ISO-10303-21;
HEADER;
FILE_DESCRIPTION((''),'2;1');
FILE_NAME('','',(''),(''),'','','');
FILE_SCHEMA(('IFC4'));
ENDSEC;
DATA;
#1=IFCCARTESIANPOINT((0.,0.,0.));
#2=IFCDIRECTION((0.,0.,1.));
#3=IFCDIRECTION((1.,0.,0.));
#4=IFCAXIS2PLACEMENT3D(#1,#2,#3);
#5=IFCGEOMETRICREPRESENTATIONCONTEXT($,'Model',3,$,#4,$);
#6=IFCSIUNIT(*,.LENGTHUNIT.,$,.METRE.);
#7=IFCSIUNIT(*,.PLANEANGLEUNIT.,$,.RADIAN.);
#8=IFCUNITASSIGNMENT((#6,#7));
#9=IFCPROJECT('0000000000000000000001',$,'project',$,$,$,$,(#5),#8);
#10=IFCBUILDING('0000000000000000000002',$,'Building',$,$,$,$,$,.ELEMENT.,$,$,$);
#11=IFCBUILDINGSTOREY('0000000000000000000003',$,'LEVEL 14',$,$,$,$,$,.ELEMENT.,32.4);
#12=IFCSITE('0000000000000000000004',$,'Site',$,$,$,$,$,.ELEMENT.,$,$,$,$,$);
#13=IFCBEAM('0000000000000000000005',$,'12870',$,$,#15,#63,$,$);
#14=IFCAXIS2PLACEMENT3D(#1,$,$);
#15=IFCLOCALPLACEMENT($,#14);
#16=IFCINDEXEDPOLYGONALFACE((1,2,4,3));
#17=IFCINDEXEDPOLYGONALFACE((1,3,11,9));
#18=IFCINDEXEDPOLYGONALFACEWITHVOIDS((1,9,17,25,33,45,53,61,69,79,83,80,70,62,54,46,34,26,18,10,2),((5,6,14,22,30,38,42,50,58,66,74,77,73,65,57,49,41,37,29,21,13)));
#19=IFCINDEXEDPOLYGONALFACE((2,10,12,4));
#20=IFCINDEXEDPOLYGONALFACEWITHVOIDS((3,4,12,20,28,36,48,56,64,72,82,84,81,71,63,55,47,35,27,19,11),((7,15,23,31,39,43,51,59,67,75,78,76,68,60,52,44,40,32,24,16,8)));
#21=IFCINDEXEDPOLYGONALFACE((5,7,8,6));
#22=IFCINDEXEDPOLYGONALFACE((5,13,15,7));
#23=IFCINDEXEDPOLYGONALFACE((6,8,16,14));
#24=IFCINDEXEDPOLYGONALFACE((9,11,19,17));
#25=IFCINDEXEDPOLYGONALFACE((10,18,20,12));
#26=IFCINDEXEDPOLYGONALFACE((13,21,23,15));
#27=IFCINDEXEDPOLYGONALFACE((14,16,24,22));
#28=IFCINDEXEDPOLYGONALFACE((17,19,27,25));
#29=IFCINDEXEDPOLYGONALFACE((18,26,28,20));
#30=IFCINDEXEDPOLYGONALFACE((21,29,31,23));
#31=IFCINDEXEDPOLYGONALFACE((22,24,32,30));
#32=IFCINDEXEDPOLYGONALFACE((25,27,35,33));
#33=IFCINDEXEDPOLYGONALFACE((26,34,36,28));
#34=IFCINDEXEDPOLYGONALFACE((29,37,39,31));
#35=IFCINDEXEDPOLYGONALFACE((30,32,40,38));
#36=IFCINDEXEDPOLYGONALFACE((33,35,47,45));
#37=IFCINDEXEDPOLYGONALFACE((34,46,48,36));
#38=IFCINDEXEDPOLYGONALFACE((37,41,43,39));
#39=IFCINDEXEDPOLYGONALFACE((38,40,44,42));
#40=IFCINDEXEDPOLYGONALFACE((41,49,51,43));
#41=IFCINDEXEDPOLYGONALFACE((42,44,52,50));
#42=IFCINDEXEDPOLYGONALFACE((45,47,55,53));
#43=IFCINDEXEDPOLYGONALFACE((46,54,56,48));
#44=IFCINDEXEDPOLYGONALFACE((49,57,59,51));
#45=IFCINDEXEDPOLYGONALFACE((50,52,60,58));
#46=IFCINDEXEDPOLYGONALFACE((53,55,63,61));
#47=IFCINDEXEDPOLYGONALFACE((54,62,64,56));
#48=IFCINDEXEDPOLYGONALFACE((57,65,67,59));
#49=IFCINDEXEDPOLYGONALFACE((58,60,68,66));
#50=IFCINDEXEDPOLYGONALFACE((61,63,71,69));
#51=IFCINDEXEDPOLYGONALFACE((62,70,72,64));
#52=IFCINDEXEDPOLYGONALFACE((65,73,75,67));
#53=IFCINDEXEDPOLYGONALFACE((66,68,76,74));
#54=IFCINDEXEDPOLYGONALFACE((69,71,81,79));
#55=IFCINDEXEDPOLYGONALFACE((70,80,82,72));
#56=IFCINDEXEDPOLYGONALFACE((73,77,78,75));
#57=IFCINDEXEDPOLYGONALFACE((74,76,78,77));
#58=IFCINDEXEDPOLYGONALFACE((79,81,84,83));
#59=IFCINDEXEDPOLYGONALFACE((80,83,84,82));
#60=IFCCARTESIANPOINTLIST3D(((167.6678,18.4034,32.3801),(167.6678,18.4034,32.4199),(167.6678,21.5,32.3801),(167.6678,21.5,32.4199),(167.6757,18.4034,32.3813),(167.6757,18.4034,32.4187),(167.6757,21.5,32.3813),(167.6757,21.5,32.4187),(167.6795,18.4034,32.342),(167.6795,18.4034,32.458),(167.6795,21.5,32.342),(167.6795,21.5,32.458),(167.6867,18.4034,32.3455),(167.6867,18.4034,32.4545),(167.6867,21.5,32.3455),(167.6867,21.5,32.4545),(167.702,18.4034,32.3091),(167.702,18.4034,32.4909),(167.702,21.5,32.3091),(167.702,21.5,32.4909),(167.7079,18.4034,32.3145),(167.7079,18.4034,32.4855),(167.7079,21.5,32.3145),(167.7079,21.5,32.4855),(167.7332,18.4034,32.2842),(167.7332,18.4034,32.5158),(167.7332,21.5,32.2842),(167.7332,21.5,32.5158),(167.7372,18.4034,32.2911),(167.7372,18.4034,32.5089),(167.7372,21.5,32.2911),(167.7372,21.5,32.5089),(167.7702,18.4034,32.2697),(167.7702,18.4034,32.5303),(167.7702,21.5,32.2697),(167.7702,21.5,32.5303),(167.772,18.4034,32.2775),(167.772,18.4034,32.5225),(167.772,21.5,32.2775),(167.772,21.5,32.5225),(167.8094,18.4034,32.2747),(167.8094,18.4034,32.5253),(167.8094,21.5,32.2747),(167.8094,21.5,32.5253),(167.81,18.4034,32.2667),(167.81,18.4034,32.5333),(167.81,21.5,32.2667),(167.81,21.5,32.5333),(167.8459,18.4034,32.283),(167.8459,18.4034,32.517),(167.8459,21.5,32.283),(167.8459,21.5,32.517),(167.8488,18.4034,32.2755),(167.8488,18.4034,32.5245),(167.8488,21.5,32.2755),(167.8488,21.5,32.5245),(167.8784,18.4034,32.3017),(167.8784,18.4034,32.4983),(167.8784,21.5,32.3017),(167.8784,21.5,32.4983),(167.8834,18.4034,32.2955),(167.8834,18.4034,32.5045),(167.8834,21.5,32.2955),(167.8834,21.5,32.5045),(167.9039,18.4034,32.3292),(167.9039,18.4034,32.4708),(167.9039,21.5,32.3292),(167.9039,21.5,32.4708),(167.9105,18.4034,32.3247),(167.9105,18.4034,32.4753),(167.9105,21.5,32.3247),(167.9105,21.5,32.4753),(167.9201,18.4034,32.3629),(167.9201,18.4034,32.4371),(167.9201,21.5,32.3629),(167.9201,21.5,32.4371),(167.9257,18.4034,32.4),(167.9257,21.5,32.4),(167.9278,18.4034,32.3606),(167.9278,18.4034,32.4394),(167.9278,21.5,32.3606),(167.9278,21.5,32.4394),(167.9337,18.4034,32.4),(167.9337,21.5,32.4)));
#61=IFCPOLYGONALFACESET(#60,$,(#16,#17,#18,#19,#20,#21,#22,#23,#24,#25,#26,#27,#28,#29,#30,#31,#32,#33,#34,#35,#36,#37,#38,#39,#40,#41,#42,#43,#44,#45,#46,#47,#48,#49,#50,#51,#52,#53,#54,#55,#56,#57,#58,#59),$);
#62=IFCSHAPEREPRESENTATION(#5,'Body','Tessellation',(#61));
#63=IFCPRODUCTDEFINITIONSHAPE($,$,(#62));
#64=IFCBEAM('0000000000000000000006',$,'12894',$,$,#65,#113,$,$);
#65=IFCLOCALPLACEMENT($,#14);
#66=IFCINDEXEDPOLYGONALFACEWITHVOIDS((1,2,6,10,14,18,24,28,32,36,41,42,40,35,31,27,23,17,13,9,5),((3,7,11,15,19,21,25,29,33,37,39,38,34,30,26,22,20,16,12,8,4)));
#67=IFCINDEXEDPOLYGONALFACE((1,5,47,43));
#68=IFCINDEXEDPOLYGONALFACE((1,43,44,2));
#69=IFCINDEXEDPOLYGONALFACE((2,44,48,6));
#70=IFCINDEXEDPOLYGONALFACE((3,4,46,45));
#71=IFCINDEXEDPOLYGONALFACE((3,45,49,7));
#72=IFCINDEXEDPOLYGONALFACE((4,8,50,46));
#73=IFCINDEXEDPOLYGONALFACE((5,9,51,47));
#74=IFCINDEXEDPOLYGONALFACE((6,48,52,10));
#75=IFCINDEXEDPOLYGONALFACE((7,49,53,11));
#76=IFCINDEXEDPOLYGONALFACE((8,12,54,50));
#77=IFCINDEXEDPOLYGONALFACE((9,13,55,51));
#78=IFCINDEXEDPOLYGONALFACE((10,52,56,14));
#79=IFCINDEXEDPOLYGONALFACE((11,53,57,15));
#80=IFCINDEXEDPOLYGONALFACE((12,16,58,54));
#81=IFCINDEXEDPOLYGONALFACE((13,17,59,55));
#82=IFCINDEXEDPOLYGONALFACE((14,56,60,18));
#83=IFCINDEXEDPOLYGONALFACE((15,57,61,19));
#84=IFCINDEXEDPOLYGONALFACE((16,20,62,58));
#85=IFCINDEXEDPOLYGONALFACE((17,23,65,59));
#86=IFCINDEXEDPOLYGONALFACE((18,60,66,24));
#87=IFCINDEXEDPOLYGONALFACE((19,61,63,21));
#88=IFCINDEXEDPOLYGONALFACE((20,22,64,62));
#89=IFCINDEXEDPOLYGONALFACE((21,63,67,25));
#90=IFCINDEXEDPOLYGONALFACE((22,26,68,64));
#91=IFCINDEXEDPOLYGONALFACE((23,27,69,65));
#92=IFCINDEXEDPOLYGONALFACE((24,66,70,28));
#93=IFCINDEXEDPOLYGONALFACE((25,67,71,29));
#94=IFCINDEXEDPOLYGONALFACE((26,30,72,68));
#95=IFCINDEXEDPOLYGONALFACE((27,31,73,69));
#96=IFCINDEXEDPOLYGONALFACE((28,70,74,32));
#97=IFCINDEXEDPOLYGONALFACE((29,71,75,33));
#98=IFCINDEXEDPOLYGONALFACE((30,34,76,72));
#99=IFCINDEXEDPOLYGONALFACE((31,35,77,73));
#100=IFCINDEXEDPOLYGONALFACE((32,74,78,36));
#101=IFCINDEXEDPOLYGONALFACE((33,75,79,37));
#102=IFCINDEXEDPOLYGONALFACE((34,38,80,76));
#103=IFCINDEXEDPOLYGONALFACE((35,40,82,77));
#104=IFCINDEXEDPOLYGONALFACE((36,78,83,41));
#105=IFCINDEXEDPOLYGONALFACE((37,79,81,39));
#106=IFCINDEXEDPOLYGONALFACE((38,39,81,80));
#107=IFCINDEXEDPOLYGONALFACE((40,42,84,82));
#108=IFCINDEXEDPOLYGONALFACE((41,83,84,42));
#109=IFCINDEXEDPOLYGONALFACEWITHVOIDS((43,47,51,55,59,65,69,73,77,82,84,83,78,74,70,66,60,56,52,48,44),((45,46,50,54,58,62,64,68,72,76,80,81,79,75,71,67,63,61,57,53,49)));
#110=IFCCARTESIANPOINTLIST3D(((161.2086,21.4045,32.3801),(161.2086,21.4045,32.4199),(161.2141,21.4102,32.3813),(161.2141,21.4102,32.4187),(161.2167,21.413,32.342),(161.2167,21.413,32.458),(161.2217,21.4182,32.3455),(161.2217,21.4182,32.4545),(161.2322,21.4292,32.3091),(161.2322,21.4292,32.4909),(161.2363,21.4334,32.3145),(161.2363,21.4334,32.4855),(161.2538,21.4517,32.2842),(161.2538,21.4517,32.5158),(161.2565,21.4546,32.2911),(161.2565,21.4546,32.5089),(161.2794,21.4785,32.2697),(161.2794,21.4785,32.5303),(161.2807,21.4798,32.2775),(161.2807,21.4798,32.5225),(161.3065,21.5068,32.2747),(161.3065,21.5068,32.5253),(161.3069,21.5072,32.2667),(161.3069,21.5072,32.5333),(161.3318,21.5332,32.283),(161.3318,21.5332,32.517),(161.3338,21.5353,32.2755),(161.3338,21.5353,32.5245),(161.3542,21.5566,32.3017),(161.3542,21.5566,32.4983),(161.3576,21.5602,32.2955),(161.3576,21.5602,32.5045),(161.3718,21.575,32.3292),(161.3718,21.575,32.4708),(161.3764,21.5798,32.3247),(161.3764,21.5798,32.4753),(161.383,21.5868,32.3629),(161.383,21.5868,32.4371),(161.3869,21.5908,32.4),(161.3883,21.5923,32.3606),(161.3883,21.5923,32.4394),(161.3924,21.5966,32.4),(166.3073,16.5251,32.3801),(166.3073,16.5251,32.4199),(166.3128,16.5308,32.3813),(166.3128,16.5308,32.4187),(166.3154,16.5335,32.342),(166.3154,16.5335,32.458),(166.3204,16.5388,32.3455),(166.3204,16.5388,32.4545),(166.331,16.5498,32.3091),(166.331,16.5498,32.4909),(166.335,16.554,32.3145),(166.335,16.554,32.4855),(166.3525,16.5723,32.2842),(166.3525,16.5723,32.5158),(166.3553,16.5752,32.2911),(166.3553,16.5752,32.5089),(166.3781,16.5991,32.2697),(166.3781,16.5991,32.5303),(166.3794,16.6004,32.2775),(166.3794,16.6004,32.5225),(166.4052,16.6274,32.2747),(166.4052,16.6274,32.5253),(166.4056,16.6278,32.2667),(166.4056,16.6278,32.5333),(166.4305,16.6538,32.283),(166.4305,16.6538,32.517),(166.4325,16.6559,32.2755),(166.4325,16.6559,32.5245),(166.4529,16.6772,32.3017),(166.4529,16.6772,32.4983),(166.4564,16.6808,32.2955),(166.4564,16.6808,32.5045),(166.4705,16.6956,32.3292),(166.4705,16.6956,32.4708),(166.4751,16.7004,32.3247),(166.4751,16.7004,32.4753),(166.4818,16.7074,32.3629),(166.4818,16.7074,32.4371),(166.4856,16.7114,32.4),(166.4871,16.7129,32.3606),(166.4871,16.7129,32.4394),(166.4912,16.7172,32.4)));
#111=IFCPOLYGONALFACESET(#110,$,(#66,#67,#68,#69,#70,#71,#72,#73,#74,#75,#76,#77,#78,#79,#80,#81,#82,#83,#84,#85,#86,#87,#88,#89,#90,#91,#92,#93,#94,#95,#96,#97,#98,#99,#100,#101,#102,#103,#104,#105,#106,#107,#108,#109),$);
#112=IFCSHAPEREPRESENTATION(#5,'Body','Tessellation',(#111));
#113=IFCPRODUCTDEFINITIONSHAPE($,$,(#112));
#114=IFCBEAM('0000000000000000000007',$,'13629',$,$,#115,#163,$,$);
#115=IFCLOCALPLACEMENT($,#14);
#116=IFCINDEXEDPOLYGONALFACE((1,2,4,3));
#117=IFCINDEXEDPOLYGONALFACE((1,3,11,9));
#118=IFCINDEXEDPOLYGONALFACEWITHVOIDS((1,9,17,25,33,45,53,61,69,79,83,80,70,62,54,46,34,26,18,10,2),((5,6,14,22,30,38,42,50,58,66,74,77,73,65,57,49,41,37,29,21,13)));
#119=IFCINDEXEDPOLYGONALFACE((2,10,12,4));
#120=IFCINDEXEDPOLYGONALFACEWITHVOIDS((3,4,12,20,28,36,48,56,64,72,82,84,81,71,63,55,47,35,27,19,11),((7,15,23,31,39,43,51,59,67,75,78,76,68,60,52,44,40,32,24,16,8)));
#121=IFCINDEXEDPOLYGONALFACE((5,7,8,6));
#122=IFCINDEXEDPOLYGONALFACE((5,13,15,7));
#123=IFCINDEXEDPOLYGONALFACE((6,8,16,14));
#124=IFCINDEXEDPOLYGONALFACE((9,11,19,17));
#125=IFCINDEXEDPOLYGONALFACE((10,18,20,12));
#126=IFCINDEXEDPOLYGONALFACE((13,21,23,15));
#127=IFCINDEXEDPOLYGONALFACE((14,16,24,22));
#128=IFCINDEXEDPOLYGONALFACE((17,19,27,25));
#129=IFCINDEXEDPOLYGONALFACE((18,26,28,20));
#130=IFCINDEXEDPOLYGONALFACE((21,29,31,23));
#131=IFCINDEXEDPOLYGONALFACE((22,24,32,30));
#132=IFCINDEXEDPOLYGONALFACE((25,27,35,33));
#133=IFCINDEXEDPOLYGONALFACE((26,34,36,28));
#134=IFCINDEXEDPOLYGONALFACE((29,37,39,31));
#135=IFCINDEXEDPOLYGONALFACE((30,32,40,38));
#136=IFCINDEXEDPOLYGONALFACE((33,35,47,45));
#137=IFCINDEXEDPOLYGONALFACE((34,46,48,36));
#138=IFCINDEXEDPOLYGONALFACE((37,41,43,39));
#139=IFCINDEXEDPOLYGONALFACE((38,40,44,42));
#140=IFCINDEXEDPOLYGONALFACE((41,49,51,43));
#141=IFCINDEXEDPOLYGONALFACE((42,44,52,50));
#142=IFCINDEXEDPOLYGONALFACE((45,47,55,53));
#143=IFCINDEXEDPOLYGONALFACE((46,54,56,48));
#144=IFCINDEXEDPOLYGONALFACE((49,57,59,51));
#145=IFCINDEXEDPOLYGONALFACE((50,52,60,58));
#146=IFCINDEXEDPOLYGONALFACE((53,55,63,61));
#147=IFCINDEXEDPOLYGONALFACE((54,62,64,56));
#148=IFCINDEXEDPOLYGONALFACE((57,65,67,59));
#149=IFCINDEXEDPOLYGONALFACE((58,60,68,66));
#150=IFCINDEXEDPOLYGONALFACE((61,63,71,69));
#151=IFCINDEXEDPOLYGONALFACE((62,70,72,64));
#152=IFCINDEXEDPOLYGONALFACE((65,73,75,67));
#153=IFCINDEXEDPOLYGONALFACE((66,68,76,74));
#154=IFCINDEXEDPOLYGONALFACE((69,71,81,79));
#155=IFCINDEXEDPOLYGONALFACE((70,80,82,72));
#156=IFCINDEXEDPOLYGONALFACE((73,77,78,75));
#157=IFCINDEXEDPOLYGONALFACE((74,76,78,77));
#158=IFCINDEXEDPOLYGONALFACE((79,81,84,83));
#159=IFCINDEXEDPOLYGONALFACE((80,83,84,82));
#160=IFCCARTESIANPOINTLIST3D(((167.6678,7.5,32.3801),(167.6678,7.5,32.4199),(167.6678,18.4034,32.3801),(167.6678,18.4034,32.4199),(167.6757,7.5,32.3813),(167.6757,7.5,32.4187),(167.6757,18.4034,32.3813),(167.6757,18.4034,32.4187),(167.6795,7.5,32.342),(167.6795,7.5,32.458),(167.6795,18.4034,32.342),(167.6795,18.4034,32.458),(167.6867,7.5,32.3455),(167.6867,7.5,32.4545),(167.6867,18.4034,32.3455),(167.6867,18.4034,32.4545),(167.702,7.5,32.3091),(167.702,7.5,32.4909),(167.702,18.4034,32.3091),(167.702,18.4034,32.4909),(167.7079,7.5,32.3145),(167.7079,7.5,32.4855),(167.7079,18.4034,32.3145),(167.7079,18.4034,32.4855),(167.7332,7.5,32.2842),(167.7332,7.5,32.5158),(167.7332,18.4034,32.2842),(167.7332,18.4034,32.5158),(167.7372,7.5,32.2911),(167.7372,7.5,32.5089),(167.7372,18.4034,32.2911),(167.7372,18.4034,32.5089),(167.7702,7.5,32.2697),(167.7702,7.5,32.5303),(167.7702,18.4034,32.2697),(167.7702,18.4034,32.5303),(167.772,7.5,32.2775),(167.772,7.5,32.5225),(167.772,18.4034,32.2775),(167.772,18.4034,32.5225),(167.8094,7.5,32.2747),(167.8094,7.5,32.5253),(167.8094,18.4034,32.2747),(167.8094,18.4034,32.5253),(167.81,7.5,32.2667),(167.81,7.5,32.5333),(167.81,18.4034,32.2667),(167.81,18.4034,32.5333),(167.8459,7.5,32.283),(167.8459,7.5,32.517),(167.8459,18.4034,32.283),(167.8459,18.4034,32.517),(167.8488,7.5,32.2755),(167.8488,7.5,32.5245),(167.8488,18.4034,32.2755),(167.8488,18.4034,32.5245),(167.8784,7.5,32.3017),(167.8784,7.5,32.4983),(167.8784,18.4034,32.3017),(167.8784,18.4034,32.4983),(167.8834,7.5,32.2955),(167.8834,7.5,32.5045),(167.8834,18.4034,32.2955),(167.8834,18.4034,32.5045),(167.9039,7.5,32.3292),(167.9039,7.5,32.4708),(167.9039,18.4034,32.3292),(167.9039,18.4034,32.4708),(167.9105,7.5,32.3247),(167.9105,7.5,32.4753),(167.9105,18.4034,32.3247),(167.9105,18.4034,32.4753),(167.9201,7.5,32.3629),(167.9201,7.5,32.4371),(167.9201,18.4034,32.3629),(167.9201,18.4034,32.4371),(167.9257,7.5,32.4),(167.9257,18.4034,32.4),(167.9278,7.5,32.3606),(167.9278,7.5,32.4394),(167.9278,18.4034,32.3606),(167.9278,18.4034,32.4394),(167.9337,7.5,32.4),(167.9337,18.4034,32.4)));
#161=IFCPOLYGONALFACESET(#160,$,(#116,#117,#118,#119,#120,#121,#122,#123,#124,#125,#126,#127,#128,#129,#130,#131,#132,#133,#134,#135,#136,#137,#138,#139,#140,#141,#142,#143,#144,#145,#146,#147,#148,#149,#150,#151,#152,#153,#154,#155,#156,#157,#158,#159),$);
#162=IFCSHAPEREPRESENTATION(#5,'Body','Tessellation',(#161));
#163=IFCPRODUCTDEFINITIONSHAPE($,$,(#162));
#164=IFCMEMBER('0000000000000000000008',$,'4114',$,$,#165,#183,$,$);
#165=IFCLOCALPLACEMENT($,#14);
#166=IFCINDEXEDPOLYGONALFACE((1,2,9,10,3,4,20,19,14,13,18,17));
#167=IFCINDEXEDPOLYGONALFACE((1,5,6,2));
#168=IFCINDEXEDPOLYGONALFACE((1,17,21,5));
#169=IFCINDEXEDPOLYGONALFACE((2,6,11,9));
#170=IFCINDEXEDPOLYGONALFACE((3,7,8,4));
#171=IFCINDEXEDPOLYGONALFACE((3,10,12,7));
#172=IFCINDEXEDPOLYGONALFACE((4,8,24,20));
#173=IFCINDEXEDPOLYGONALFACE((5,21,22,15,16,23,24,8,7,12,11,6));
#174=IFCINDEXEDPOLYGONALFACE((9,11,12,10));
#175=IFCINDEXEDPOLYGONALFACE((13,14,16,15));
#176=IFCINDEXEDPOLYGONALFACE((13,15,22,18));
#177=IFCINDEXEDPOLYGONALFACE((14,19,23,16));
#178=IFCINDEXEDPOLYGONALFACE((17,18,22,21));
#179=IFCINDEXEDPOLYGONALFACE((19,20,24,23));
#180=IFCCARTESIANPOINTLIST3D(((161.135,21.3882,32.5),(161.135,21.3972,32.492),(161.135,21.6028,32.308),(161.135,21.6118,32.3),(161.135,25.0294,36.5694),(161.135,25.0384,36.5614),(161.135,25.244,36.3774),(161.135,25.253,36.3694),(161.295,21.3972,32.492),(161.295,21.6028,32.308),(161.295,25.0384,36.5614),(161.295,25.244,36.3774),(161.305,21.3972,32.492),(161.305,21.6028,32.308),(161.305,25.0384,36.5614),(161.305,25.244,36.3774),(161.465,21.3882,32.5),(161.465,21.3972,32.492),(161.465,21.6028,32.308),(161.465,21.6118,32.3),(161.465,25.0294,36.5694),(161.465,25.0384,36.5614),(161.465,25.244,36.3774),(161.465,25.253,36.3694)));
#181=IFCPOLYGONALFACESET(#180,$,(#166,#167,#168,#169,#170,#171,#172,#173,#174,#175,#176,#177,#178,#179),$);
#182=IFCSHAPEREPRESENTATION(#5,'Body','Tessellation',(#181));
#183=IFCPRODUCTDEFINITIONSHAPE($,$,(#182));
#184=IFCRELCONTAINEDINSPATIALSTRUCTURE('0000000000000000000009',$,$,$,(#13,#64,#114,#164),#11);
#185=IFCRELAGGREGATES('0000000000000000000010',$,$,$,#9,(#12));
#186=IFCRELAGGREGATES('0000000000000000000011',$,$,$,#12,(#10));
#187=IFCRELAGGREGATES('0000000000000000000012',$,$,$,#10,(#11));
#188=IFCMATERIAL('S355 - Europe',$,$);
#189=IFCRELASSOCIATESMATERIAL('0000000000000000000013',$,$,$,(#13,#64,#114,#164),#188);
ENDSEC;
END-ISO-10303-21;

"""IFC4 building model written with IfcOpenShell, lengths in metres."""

from ifc_helpers import new_model, si_unit, frame, origin_with_axes, origin_2d_with_axis, place, context, project, spatial, hollow_circle, i_section, extrude, material, material_profile, profile_set, profile_usage, element, save


model = new_model("IFC4")

# Units and contexts
model_context = context("Model", 3, world=origin_with_axes())
ifc_project = project(units=[si_unit("LENGTHUNIT", "METRE"), si_unit("PLANEANGLEUNIT", "RADIAN")], contexts=[model_context])

# Site, building, storey
site = spatial("IfcSite", under=ifc_project, Name="Site", CompositionType="ELEMENT")
building = spatial("IfcBuilding", under=site, Name="Building", CompositionType="ELEMENT")
storey = spatial("IfcBuildingStorey", under=building, Name="LEVEL 14", CompositionType="ELEMENT", Elevation=32.4)

# Shared definitions
ifc_material = material(Name="S355 - Europe")

# Beams
ifc_material_profile_1 = material_profile(ifc_material, hollow_circle(Radius=0.1337, WallThickness=0.008, at=origin_2d_with_axis()))
ifc_profile_set_1 = profile_set([ifc_material_profile_1])
ifc_profile_usage_1 = profile_usage(ifc_profile_set_1, cardinal=10)
beam_1_placement = place(None, frame((167.8, 21.5, 32.4), z_axis=(0.0, -1.0, 0.0), x_axis=(1.0, 0.0, 0.0)))
element("IfcBeam", 1, at=beam_1_placement, inside=storey, material=ifc_profile_usage_1, Name="12870", context=model_context, shape_type="SweptSolid", body=[
    extrude(hollow_circle(Radius=0.1337, WallThickness=0.008, at=origin_2d_with_axis()), origin_with_axes(), (0.0, 0.0, 1.0), 3.0966),
])
ifc_material_profile_2 = material_profile(ifc_material, hollow_circle(Radius=0.1337, WallThickness=0.008, at=origin_2d_with_axis()))
ifc_profile_set_2 = profile_set([ifc_material_profile_2])
ifc_profile_usage_2 = profile_usage(ifc_profile_set_2, cardinal=10)
beam_2_placement = place(None, frame((161.3, 21.5, 32.4), z_axis=(0.722473, -0.691399, 0.0), x_axis=(0.691399, 0.722473, 0.0)))
element("IfcBeam", 2, at=beam_2_placement, inside=storey, material=ifc_profile_usage_2, Name="12894", context=model_context, shape_type="SweptSolid", body=[
    extrude(hollow_circle(Radius=0.1337, WallThickness=0.008, at=origin_2d_with_axis()), origin_with_axes(), (0.0, 0.0, 1.0), 7.0573),
])
ifc_material_profile_3 = material_profile(ifc_material, hollow_circle(Radius=0.1337, WallThickness=0.008, at=origin_2d_with_axis()))
ifc_profile_set_3 = profile_set([ifc_material_profile_3])
ifc_profile_usage_3 = profile_usage(ifc_profile_set_3, cardinal=10)
beam_3_placement = place(None, frame((167.8, 18.4034, 32.4), z_axis=(0.0, -1.0, 0.0), x_axis=(1.0, 0.0, 0.0)))
element("IfcBeam", 3, at=beam_3_placement, inside=storey, material=ifc_profile_usage_3, Name="13629", context=model_context, shape_type="SweptSolid", body=[
    extrude(hollow_circle(Radius=0.1337, WallThickness=0.008, at=origin_2d_with_axis()), origin_with_axes(), (0.0, 0.0, 1.0), 10.9034),
])

# Member
ifc_material_profile_4 = material_profile(ifc_material, i_section(OverallWidth=0.33, OverallDepth=0.3, WebThickness=0.01, FlangeThickness=0.012, at=origin_2d_with_axis()))
ifc_profile_set_4 = profile_set([ifc_material_profile_4])
ifc_profile_usage_4 = profile_usage(ifc_profile_set_4, cardinal=10)
member_1_placement = place(None, frame((161.3, 21.5, 32.4), z_axis=(0.0, 0.666811, 0.745227), x_axis=(-1.0, 0.0, 0.0)))
element("IfcMember", 4, at=member_1_placement, inside=storey, material=ifc_profile_usage_4, Name="4114", context=model_context, shape_type="SweptSolid", body=[
    extrude(i_section(OverallWidth=0.33, OverallDepth=0.3, WebThickness=0.01, FlangeThickness=0.012, at=origin_2d_with_axis()), origin_with_axes(), (0.0, 0.0, 1.0), 5.4606),
])

save(model, "model.ifc")
